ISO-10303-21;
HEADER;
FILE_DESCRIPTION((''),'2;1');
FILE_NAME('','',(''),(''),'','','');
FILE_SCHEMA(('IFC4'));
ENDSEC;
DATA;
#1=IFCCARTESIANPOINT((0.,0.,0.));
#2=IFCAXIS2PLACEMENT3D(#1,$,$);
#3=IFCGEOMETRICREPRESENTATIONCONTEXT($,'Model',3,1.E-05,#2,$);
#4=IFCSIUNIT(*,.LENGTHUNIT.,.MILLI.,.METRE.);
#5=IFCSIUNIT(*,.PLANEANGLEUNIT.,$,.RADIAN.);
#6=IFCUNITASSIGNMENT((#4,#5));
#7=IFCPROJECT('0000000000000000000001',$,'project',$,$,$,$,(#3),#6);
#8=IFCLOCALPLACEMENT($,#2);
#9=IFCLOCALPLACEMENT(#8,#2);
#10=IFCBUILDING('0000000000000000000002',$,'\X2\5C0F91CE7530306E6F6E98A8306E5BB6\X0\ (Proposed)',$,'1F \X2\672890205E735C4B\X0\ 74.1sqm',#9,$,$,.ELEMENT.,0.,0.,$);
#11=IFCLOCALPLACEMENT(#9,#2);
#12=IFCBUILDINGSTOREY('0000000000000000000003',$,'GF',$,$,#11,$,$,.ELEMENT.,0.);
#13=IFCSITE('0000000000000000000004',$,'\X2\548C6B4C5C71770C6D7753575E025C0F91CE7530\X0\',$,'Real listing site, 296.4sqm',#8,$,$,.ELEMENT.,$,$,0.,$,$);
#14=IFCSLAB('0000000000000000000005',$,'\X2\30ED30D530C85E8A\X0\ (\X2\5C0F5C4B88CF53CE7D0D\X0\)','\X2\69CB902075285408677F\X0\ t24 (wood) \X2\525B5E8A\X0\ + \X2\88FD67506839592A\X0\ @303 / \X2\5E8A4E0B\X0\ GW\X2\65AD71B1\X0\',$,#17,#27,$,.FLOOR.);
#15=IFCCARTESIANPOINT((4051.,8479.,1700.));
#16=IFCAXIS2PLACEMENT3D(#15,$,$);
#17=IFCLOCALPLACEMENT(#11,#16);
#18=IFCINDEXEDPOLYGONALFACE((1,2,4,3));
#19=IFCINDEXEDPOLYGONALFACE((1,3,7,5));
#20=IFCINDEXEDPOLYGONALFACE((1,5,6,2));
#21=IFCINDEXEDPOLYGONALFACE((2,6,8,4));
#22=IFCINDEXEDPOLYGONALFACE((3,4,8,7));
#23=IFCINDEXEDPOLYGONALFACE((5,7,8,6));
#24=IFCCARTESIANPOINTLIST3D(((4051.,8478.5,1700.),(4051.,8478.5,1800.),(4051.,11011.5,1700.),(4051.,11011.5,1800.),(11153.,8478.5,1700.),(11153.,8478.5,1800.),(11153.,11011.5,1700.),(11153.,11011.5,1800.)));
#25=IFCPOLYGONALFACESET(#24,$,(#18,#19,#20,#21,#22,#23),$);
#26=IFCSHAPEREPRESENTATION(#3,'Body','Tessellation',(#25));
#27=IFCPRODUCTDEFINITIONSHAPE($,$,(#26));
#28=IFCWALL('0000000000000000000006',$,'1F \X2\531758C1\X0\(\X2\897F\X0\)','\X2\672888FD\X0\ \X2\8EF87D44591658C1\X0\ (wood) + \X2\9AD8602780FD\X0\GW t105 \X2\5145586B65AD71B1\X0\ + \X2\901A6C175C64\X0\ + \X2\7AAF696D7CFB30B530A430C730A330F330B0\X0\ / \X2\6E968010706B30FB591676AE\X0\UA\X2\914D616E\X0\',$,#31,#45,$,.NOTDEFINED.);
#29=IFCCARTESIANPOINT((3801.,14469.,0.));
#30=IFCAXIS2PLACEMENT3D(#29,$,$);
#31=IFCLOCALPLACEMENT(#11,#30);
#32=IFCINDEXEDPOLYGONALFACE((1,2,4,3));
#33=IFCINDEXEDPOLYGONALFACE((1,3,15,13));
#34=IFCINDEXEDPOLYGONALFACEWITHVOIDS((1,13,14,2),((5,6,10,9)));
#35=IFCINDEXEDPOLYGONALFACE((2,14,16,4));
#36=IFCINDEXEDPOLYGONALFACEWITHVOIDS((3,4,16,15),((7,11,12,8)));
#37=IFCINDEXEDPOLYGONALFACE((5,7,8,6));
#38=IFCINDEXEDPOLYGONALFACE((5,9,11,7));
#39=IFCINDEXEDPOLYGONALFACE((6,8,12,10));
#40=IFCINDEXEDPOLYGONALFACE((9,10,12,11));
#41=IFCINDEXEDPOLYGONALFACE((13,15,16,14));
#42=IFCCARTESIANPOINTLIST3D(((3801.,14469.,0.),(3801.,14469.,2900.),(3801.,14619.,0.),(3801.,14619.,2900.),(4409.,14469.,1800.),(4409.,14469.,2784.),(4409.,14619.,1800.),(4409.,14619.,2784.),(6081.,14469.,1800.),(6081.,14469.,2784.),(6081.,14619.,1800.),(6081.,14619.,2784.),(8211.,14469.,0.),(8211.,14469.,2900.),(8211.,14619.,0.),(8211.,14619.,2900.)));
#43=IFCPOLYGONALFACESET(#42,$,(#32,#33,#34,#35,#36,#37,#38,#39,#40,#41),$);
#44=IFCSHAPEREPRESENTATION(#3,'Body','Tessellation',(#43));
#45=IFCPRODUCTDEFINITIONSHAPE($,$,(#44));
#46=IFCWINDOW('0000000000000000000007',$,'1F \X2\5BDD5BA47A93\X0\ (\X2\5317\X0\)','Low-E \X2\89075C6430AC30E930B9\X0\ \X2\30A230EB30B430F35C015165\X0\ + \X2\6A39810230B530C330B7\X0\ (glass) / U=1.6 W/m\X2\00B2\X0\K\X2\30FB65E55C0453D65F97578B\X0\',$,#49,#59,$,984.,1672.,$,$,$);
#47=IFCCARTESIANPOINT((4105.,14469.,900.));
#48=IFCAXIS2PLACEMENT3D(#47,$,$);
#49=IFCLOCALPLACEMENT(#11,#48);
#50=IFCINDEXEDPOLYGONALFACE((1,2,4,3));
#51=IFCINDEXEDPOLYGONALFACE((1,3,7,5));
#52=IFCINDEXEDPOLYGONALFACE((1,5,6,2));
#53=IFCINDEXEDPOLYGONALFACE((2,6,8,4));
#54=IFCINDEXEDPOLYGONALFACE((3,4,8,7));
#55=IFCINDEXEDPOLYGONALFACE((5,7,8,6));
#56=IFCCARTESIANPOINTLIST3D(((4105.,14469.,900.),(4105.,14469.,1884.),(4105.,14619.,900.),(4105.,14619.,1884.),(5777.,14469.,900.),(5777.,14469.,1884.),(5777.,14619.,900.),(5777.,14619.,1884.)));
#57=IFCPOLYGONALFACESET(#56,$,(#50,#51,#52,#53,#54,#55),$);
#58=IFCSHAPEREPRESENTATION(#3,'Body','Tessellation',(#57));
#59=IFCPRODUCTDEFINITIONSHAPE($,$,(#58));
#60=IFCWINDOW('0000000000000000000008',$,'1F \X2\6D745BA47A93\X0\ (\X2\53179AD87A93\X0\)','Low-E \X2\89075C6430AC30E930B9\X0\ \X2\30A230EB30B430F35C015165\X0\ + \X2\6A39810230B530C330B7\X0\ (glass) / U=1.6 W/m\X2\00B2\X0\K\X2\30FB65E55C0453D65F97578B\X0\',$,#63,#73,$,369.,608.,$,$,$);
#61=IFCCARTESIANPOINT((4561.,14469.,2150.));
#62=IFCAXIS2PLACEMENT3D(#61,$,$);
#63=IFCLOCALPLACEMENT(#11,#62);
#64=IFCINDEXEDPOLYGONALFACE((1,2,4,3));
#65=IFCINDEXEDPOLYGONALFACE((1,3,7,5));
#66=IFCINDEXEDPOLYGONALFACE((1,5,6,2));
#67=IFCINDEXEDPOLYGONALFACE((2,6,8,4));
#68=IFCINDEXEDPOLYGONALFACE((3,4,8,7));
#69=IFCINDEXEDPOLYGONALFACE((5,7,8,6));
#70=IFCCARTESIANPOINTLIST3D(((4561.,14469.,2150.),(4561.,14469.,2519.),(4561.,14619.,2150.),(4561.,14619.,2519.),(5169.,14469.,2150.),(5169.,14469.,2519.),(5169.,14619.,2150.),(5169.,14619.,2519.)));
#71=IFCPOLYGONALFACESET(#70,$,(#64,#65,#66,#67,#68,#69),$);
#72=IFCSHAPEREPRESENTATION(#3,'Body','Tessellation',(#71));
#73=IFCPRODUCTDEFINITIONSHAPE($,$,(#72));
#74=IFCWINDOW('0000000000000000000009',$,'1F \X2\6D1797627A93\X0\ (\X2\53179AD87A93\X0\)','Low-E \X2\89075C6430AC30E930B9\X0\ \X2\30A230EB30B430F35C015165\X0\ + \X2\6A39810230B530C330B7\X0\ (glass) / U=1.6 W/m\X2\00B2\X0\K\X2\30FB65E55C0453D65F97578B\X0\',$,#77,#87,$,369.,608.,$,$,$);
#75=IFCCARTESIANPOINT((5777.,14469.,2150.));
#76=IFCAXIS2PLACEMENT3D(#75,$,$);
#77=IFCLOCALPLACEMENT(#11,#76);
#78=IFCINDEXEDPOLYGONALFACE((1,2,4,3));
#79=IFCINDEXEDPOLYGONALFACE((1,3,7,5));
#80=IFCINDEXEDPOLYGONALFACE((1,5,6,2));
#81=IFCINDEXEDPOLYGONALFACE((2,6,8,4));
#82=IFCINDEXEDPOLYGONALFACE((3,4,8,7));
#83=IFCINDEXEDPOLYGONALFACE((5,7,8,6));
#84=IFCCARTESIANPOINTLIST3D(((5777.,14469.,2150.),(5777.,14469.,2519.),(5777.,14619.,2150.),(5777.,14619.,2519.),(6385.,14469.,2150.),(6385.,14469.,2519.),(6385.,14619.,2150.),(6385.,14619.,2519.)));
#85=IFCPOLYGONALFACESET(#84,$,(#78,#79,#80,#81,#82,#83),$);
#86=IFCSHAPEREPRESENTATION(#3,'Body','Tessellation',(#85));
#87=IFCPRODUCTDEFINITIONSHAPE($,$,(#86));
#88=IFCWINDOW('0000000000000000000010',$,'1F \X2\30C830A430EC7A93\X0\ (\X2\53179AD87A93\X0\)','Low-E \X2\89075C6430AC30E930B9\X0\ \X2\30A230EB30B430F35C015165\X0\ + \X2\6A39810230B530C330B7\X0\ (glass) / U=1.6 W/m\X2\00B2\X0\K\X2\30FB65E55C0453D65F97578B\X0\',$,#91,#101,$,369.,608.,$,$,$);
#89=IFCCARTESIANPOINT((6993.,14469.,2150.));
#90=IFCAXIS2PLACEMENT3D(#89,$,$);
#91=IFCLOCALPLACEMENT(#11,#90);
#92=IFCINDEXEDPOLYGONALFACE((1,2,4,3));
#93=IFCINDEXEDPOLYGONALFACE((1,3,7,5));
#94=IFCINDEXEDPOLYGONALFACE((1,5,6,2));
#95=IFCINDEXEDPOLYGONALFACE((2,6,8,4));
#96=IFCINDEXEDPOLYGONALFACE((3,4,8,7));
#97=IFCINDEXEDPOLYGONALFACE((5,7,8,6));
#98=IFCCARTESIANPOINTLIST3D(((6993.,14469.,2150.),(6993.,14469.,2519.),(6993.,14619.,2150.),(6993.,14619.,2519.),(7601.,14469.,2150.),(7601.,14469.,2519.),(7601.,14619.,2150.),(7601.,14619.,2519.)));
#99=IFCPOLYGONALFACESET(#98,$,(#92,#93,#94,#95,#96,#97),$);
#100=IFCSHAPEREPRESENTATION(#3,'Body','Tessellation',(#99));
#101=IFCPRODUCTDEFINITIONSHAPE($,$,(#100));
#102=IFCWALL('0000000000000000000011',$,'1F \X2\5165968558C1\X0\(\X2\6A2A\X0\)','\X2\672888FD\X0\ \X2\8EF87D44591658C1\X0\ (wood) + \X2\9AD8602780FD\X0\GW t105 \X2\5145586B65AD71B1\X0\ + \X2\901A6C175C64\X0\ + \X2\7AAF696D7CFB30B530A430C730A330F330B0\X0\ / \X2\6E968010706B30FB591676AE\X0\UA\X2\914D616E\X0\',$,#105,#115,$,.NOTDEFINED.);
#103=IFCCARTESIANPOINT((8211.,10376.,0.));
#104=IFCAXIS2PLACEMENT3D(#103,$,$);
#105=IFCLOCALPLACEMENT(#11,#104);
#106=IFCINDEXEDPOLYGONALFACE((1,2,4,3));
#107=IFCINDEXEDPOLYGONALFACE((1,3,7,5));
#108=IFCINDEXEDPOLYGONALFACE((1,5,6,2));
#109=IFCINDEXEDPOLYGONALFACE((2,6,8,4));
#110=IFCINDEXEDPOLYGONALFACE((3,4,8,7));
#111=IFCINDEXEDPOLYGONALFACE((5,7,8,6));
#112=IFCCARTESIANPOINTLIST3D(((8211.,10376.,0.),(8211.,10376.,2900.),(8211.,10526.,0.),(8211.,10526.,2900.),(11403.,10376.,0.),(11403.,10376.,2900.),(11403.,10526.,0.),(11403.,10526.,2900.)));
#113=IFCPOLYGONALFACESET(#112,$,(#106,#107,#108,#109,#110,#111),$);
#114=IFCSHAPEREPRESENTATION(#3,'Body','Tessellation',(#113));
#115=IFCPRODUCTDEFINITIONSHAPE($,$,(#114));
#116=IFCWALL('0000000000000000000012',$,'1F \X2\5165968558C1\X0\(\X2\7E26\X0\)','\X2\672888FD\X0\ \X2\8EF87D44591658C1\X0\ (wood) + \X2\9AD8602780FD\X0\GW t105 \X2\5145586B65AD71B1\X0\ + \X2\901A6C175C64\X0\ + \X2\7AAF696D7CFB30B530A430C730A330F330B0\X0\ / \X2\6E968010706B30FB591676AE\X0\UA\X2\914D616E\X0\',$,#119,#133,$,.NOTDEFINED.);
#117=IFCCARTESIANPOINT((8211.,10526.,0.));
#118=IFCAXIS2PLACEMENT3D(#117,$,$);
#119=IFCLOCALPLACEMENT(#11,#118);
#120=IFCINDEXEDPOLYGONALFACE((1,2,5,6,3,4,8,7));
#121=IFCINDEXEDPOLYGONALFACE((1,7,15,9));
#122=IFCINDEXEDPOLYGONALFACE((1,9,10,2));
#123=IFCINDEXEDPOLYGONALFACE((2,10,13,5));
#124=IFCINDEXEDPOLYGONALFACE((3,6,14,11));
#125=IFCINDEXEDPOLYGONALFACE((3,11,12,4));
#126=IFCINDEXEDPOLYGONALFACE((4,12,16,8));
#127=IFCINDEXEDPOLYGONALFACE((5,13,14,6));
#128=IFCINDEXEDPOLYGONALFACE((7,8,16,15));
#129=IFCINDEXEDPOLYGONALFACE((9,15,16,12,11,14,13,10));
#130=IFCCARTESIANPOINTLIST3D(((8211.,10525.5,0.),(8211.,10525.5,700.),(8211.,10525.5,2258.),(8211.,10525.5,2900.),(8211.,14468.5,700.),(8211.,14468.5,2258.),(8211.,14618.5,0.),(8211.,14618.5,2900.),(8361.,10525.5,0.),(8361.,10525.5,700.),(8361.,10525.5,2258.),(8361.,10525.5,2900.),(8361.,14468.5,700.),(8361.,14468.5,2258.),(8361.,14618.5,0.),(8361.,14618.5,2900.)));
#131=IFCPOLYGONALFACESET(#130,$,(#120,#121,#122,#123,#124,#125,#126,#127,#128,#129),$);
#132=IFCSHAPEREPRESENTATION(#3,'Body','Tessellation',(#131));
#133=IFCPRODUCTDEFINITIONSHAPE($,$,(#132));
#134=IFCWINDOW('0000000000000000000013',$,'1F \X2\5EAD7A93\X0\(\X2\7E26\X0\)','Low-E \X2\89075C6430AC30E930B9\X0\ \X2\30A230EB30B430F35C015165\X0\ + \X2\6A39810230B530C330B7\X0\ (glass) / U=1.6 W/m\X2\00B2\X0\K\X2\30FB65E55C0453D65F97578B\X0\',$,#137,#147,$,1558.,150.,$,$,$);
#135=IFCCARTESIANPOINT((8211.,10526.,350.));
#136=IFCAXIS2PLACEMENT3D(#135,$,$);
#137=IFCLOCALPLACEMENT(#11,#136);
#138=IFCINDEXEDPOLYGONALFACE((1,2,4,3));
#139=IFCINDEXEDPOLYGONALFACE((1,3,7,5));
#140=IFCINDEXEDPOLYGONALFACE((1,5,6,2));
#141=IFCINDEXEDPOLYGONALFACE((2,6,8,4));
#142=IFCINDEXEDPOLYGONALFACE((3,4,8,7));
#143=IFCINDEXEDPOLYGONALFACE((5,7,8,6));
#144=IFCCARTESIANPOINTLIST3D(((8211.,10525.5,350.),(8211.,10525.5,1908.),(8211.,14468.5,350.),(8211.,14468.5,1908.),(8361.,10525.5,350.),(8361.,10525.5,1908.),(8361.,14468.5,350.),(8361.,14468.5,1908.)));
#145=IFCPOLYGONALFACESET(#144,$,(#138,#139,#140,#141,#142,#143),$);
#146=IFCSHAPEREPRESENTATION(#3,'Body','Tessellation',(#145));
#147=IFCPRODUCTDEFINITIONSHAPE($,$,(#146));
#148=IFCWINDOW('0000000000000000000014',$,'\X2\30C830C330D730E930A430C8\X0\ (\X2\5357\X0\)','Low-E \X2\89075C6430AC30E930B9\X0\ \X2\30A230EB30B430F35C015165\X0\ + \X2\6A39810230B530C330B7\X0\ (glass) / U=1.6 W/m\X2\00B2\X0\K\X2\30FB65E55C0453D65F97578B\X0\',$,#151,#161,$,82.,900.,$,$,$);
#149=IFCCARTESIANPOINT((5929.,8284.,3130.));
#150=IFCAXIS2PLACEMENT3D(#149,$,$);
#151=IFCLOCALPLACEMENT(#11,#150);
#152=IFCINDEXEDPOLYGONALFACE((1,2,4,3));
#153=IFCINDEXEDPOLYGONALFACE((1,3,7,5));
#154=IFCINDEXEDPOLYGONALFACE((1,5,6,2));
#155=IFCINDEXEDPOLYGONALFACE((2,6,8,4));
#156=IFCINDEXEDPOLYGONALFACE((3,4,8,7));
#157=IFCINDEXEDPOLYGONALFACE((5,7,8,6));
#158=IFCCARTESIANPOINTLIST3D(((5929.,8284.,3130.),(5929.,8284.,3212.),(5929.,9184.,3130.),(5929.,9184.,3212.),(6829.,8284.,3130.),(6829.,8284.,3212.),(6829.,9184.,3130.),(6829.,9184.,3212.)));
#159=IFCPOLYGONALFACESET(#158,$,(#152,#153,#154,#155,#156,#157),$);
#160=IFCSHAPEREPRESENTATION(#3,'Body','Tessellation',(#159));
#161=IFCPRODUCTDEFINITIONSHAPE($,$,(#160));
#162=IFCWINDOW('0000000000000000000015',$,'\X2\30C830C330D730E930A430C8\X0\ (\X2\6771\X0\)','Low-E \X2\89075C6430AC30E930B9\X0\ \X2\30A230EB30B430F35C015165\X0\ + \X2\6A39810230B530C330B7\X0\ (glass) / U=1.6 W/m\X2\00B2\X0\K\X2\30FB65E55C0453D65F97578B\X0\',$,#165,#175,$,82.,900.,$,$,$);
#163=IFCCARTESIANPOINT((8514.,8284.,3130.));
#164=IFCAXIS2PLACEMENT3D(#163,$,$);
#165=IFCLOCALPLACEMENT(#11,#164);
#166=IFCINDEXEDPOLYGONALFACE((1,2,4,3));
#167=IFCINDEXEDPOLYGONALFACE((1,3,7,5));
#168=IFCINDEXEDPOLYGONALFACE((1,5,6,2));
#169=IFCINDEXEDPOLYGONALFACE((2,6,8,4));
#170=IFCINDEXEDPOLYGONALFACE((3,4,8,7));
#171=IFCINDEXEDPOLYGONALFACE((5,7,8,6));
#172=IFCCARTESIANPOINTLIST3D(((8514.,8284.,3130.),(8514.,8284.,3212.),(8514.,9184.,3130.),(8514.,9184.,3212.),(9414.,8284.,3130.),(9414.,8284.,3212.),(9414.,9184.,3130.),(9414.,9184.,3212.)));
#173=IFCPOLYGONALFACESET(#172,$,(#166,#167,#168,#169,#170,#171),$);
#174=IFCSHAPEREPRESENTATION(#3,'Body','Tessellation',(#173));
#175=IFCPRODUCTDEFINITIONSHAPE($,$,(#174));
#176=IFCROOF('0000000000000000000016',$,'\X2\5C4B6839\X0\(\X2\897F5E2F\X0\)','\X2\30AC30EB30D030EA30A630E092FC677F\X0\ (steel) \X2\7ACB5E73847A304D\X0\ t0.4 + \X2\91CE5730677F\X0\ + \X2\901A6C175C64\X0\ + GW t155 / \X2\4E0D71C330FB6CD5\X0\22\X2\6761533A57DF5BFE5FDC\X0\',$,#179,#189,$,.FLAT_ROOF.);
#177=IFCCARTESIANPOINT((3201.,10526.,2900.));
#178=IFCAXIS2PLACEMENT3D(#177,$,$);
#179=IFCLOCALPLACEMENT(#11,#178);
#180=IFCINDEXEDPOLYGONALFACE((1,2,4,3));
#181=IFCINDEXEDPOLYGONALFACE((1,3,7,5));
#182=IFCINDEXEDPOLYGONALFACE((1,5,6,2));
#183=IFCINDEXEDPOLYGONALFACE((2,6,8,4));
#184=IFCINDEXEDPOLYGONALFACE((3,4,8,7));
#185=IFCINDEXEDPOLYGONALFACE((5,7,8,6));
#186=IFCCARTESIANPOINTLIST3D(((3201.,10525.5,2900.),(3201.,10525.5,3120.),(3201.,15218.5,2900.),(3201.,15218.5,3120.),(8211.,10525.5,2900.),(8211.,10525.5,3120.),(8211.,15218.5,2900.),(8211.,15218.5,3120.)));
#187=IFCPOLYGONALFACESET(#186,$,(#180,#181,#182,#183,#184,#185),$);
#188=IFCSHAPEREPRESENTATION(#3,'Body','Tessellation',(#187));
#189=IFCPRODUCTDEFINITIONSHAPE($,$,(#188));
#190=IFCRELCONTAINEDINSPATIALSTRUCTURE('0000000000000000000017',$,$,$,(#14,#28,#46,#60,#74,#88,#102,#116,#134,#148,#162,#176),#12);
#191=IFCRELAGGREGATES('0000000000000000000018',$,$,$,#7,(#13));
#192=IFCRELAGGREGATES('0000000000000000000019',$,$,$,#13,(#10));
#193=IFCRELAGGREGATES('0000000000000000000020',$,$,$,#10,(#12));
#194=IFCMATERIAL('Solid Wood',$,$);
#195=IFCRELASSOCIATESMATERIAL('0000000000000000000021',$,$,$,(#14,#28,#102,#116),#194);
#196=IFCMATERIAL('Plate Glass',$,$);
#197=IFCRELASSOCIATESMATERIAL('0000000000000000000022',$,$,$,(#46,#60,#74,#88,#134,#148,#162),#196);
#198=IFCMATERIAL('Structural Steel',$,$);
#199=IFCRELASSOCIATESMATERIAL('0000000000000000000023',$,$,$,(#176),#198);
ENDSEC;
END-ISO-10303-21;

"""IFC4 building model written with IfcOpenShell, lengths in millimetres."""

from ifc_helpers import new_model, si_unit, frame, frame_2d, origin, place, context, project, spatial, rectangle, extrude, material, element, fill, save


model = new_model("IFC4")

# Units and contexts
model_context = context("Model", 3, precision=1e-05, world=origin())
ifc_project = project(units=[si_unit("LENGTHUNIT", "METRE", prefix="MILLI"), si_unit("PLANEANGLEUNIT", "RADIAN")], contexts=[model_context])

# Site, building, storey
site_placement = place(None, origin())
site = spatial("IfcSite", under=ifc_project, at=site_placement, Name="和歌山県海南市小野田", ObjectType="Real listing site, 296.4sqm", CompositionType="ELEMENT", RefElevation=0.0)
building_placement = place(site_placement, origin())
building = spatial("IfcBuilding", under=site, at=building_placement, Name="小野田の潮風の家 (Proposed)", ObjectType="1F 木造平屋 74.1sqm", CompositionType="ELEMENT", ElevationOfRefHeight=0.0, ElevationOfTerrain=0.0)
storey_placement = place(building_placement, origin())
storey = spatial("IfcBuildingStorey", under=building, at=storey_placement, Name="GF", CompositionType="ELEMENT", Elevation=0.0)

# Slab
ifc_material_1 = material(Name="Solid Wood")
slab_1_placement = place(storey_placement, frame((4051.0, 8479.0, 1700.0)))
element("IfcSlab", 1, at=slab_1_placement, inside=storey, material=ifc_material_1, Name="ロフト床 (小屋裏収納)", Description="構造用合板 t24 (wood) 剛床 + 製材根太 @303 / 床下 GW断熱", PredefinedType="FLOOR", context=model_context, shape_type="SweptSolid", body=[
    extrude(rectangle(XDim=7102.0, YDim=2533.0, at=frame_2d((3551.0, 1266.0))), frame((4051.0, 8479.0, 1700.0)), (0.0, 0.0, 1.0), 100.0),
])

# Wall, openings, windows
wall_1_placement = place(storey_placement, frame((3801.0, 14469.0, 0.0)))
wall_1 = element("IfcWall", 2, at=wall_1_placement, inside=storey, material=ifc_material_1, Name="1F 北壁(西)", Description="木製 軸組外壁 (wood) + 高性能GW t105 充填断熱 + 通気層 + 窯業系サイディング / 準耐火・外皮UA配慮", PredefinedType="NOTDEFINED", context=model_context, shape_type="SweptSolid", body=[
    extrude(rectangle(XDim=4410.0, YDim=150.0, at=frame_2d((2205.0, 75.0))), frame((3801.0, 14469.0, 0.0)), (0.0, 0.0, 1.0), 2900.0),
])
opening_1_placement = place(storey_placement, frame((4105.0, 14469.0, 900.0)))
opening_1 = element("IfcOpeningElement", 3, at=opening_1_placement, cuts=wall_1, PredefinedType="NOTDEFINED", context=model_context, shape_type="SweptSolid", body=[
    extrude(rectangle(XDim=1672.0, YDim=150.0, at=frame_2d((836.0, 75.0))), frame((4105.0, 14469.0, 900.0)), (0.0, 0.0, 1.0), 984.0),
])
opening_2_placement = place(storey_placement, frame((4561.0, 14469.0, 2150.0)))
opening_2 = element("IfcOpeningElement", 4, at=opening_2_placement, cuts=wall_1, PredefinedType="NOTDEFINED", context=model_context, shape_type="SweptSolid", body=[
    extrude(rectangle(XDim=608.0, YDim=150.0, at=frame_2d((304.0, 75.0))), frame((4561.0, 14469.0, 2150.0)), (0.0, 0.0, 1.0), 369.0),
])
opening_3_placement = place(storey_placement, frame((5777.0, 14469.0, 2150.0)))
opening_3 = element("IfcOpeningElement", 5, at=opening_3_placement, cuts=wall_1, PredefinedType="NOTDEFINED", context=model_context, shape_type="SweptSolid", body=[
    extrude(rectangle(XDim=608.0, YDim=150.0, at=frame_2d((304.0, 75.0))), frame((5777.0, 14469.0, 2150.0)), (0.0, 0.0, 1.0), 369.0),
])
opening_4_placement = place(storey_placement, frame((6993.0, 14469.0, 2150.0)))
opening_4 = element("IfcOpeningElement", 6, at=opening_4_placement, cuts=wall_1, PredefinedType="NOTDEFINED", context=model_context, shape_type="SweptSolid", body=[
    extrude(rectangle(XDim=608.0, YDim=150.0, at=frame_2d((304.0, 75.0))), frame((6993.0, 14469.0, 2150.0)), (0.0, 0.0, 1.0), 369.0),
])
ifc_material_2 = material(Name="Plate Glass")
window_1_placement = place(storey_placement, frame((4105.0, 14469.0, 900.0)))
window_1 = element("IfcWindow", 7, at=window_1_placement, inside=storey, material=ifc_material_2, Name="1F 寝室窓 (北)", Description="Low-E 複層ガラス アルゴン封入 + 樹脂サッシ (glass) / U=1.6 W/m²K・日射取得型", OverallHeight=984.0, OverallWidth=1672.0, context=model_context, shape_type="SweptSolid", body=[
    extrude(rectangle(XDim=1672.0, YDim=150.0, at=frame_2d((836.0, 75.0))), frame((4105.0, 14469.0, 900.0)), (0.0, 0.0, 1.0), 984.0),
])
fill(opening_1, window_1)
window_2_placement = place(storey_placement, frame((4561.0, 14469.0, 2150.0)))
window_2 = element("IfcWindow", 8, at=window_2_placement, inside=storey, material=ifc_material_2, Name="1F 浴室窓 (北高窓)", Description="Low-E 複層ガラス アルゴン封入 + 樹脂サッシ (glass) / U=1.6 W/m²K・日射取得型", OverallHeight=369.0, OverallWidth=608.0, context=model_context, shape_type="SweptSolid", body=[
    extrude(rectangle(XDim=608.0, YDim=150.0, at=frame_2d((304.0, 75.0))), frame((4561.0, 14469.0, 2150.0)), (0.0, 0.0, 1.0), 369.0),
])
fill(opening_2, window_2)
window_3_placement = place(storey_placement, frame((5777.0, 14469.0, 2150.0)))
window_3 = element("IfcWindow", 9, at=window_3_placement, inside=storey, material=ifc_material_2, Name="1F 洗面窓 (北高窓)", Description="Low-E 複層ガラス アルゴン封入 + 樹脂サッシ (glass) / U=1.6 W/m²K・日射取得型", OverallHeight=369.0, OverallWidth=608.0, context=model_context, shape_type="SweptSolid", body=[
    extrude(rectangle(XDim=608.0, YDim=150.0, at=frame_2d((304.0, 75.0))), frame((5777.0, 14469.0, 2150.0)), (0.0, 0.0, 1.0), 369.0),
])
fill(opening_3, window_3)
window_4_placement = place(storey_placement, frame((6993.0, 14469.0, 2150.0)))
window_4 = element("IfcWindow", 10, at=window_4_placement, inside=storey, material=ifc_material_2, Name="1F トイレ窓 (北高窓)", Description="Low-E 複層ガラス アルゴン封入 + 樹脂サッシ (glass) / U=1.6 W/m²K・日射取得型", OverallHeight=369.0, OverallWidth=608.0, context=model_context, shape_type="SweptSolid", body=[
    extrude(rectangle(XDim=608.0, YDim=150.0, at=frame_2d((304.0, 75.0))), frame((6993.0, 14469.0, 2150.0)), (0.0, 0.0, 1.0), 369.0),
])
fill(opening_4, window_4)

# Wall
wall_2_placement = place(storey_placement, frame((8211.0, 10376.0, 0.0)))
element("IfcWall", 11, at=wall_2_placement, inside=storey, material=ifc_material_1, Name="1F 入隅壁(横)", Description="木製 軸組外壁 (wood) + 高性能GW t105 充填断熱 + 通気層 + 窯業系サイディング / 準耐火・外皮UA配慮", PredefinedType="NOTDEFINED", context=model_context, shape_type="SweptSolid", body=[
    extrude(rectangle(XDim=3192.0, YDim=150.0, at=frame_2d((1596.0, 75.0))), frame((8211.0, 10376.0, 0.0)), (0.0, 0.0, 1.0), 2900.0),
])

# Wall, opening, window
wall_3_placement = place(storey_placement, frame((8211.0, 10526.0, 0.0)))
wall_3 = element("IfcWall", 12, at=wall_3_placement, inside=storey, material=ifc_material_1, Name="1F 入隅壁(縦)", Description="木製 軸組外壁 (wood) + 高性能GW t105 充填断熱 + 通気層 + 窯業系サイディング / 準耐火・外皮UA配慮", PredefinedType="NOTDEFINED", context=model_context, shape_type="SweptSolid", body=[
    extrude(rectangle(XDim=150.0, YDim=4093.0, at=frame_2d((75.0, 2046.0))), frame((8211.0, 10526.0, 0.0)), (0.0, 0.0, 1.0), 2900.0),
])
opening_5_placement = place(storey_placement, frame((8211.0, 10526.0, 350.0)))
opening_5 = element("IfcOpeningElement", 13, at=opening_5_placement, cuts=wall_3, PredefinedType="NOTDEFINED", context=model_context, shape_type="SweptSolid", body=[
    extrude(rectangle(XDim=150.0, YDim=3943.0, at=frame_2d((75.0, 1971.0))), frame((8211.0, 10526.0, 350.0)), (0.0, 0.0, 1.0), 1558.0),
])
window_5_placement = place(storey_placement, frame((8211.0, 10526.0, 350.0)))
window_5 = element("IfcWindow", 14, at=window_5_placement, inside=storey, material=ifc_material_2, Name="1F 庭窓(縦)", Description="Low-E 複層ガラス アルゴン封入 + 樹脂サッシ (glass) / U=1.6 W/m²K・日射取得型", OverallHeight=1558.0, OverallWidth=150.0, context=model_context, shape_type="SweptSolid", body=[
    extrude(rectangle(XDim=150.0, YDim=3943.0, at=frame_2d((75.0, 1971.0))), frame((8211.0, 10526.0, 350.0)), (0.0, 0.0, 1.0), 1558.0),
])
fill(opening_5, window_5)

# Windows
window_6_placement = place(storey_placement, frame((5929.0, 8284.0, 3130.0)))
element("IfcWindow", 15, at=window_6_placement, inside=storey, material=ifc_material_2, Name="トップライト (南)", Description="Low-E 複層ガラス アルゴン封入 + 樹脂サッシ (glass) / U=1.6 W/m²K・日射取得型", OverallHeight=82.0, OverallWidth=900.0, context=model_context, shape_type="SweptSolid", body=[
    extrude(rectangle(XDim=900.0, YDim=900.0, at=frame_2d((450.0, 450.0))), frame((5929.0, 8284.0, 3130.0)), (0.0, 0.0, 1.0), 82.0),
])
window_7_placement = place(storey_placement, frame((8514.0, 8284.0, 3130.0)))
element("IfcWindow", 16, at=window_7_placement, inside=storey, material=ifc_material_2, Name="トップライト (東)", Description="Low-E 複層ガラス アルゴン封入 + 樹脂サッシ (glass) / U=1.6 W/m²K・日射取得型", OverallHeight=82.0, OverallWidth=900.0, context=model_context, shape_type="SweptSolid", body=[
    extrude(rectangle(XDim=900.0, YDim=900.0, at=frame_2d((450.0, 450.0))), frame((8514.0, 8284.0, 3130.0)), (0.0, 0.0, 1.0), 82.0),
])

# Roof
ifc_material_3 = material(Name="Structural Steel")
roof_placement = place(storey_placement, frame((3201.0, 10526.0, 2900.0)))
element("IfcRoof", 17, at=roof_placement, inside=storey, material=ifc_material_3, Name="屋根(西帯)", Description="ガルバリウム鋼板 (steel) 立平葺き t0.4 + 野地板 + 通気層 + GW t155 / 不燃・法22条区域対応", PredefinedType="FLAT_ROOF", context=model_context, shape_type="SweptSolid", body=[
    extrude(rectangle(XDim=5010.0, YDim=4693.0, at=frame_2d((2505.0, 2346.0))), frame((3201.0, 10526.0, 2900.0)), (0.0, 0.0, 1.0), 220.0),
])

save(model, "model.ifc")
